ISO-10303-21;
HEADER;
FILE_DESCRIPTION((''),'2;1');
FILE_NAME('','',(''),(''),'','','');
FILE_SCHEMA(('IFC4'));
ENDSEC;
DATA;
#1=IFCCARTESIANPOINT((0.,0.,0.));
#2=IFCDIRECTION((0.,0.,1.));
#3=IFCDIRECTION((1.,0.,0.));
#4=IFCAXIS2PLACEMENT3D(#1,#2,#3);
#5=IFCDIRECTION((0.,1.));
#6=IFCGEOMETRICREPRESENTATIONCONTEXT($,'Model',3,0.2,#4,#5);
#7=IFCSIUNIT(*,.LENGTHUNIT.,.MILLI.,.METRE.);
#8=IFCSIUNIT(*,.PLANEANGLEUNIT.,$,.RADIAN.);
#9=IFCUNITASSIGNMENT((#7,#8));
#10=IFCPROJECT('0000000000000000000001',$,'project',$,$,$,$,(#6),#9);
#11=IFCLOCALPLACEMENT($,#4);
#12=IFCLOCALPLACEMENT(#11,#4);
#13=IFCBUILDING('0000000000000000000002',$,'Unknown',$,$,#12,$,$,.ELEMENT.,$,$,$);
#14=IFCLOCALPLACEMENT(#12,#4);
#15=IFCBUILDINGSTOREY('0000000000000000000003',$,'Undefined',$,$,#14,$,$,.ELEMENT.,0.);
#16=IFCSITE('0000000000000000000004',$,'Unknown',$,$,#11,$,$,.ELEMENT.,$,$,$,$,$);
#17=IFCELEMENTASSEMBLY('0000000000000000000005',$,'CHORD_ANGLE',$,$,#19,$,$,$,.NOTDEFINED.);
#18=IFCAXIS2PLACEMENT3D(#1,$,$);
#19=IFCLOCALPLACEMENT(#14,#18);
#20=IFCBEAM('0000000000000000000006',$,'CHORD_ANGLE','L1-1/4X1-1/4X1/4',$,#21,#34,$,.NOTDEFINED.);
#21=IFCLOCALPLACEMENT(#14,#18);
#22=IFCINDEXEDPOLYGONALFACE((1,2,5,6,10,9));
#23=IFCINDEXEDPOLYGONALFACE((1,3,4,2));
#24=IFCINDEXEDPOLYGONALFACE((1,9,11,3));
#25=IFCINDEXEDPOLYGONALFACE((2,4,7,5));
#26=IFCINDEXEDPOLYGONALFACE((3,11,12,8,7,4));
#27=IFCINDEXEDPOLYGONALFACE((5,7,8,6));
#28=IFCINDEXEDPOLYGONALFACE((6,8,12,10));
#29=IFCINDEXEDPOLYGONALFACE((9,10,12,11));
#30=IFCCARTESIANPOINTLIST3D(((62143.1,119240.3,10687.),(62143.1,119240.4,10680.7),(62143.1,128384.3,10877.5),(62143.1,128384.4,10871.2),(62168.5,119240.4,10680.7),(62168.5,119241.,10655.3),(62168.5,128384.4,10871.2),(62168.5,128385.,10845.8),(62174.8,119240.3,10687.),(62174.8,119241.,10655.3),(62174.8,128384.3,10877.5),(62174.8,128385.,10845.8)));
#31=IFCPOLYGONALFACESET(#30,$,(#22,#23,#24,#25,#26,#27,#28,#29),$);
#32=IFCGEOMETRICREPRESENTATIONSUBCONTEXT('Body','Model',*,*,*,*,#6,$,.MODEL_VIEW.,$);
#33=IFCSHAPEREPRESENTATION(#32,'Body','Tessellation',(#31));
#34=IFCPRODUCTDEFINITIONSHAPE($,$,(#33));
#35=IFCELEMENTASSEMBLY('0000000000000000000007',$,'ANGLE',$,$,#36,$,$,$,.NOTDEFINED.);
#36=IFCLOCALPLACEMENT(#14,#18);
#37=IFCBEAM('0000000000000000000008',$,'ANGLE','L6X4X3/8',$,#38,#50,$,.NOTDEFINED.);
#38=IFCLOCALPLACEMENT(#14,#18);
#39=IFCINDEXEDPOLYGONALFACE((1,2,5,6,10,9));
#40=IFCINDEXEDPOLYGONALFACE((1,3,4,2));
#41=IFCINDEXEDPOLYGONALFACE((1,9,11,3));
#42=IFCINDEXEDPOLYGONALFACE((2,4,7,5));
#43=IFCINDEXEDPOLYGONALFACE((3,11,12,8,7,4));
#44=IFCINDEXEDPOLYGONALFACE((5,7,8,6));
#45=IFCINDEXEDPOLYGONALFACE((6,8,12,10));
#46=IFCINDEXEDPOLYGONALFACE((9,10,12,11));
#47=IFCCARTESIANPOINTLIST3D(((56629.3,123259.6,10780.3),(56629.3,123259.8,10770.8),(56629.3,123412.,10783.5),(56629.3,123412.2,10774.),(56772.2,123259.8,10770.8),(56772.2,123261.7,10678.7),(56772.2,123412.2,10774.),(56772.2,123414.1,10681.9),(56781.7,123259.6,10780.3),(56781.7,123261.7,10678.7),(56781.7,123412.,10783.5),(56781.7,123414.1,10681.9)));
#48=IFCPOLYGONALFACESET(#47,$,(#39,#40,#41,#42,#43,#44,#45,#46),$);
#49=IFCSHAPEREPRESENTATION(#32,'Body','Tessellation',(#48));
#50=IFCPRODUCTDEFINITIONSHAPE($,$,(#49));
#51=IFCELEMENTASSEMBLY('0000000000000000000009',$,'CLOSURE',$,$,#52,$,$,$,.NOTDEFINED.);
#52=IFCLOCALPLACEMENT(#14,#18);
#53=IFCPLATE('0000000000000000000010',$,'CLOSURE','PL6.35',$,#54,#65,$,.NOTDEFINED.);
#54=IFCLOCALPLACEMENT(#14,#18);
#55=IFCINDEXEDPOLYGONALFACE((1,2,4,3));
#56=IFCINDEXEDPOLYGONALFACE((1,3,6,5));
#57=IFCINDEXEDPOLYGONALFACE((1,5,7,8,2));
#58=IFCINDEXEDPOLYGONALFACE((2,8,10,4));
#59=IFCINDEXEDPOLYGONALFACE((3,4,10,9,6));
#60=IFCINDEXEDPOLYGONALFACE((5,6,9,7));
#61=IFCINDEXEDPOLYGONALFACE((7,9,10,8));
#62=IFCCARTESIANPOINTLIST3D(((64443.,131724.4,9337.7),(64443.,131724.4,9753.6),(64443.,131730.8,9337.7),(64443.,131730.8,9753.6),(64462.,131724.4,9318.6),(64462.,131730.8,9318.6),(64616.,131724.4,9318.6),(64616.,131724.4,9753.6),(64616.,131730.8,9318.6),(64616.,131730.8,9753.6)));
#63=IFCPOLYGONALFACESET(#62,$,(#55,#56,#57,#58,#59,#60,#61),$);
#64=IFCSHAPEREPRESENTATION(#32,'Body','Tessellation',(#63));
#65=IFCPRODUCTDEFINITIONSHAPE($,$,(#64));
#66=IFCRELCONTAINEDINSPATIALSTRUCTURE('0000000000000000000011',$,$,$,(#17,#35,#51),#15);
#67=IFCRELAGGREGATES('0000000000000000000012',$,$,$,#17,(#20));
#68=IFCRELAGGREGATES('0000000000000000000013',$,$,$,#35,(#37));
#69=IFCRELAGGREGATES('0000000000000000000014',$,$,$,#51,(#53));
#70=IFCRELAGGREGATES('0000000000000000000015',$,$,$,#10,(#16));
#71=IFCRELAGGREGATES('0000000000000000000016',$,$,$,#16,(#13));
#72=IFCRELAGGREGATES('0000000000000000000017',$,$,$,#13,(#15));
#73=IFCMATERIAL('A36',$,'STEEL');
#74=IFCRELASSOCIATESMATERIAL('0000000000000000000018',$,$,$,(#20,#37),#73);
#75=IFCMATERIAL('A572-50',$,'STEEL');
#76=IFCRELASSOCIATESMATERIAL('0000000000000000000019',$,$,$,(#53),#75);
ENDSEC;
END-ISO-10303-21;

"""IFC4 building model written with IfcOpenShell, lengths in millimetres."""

from ifc_helpers import new_model, si_unit, direction, frame, origin_with_axes, place, context, subcontext, project, spatial, line, indexed_curve, outline, extrude, material, element, aggregate, save


model = new_model("IFC4")

# Units and contexts
model_context = context("Model", 3, precision=0.2, world=origin_with_axes(), true_north=direction((0.0, 1.0)))
body_context = subcontext(model_context, "Body", "Model", "MODEL_VIEW")
ifc_project = project(units=[si_unit("LENGTHUNIT", "METRE", prefix="MILLI"), si_unit("PLANEANGLEUNIT", "RADIAN")], contexts=[model_context])

# Site, building, storey
site_placement = place(None, origin_with_axes())
site = spatial("IfcSite", under=ifc_project, at=site_placement, Name="Unknown", CompositionType="ELEMENT")
building_placement = place(site_placement, origin_with_axes())
building = spatial("IfcBuilding", under=site, at=building_placement, Name="Unknown", CompositionType="ELEMENT")
storey_placement = place(building_placement, origin_with_axes())
storey = spatial("IfcBuildingStorey", under=building, at=storey_placement, Name="Undefined", CompositionType="ELEMENT", Elevation=0.0)

# Shared definitions
ifc_material_1 = material(Name="A572-50", Category="STEEL")

# Element assemblies, beams
ifc_material_2 = material(Name="A36", Category="STEEL")
assembly_1_placement = place(storey_placement, frame((62158.9, 128384.6, 10861.7), z_axis=(0.0, 0.020829, -0.999783), x_axis=(0.0, -0.999783, -0.020831)))
assembly_1 = element("IfcElementAssembly", 1, at=assembly_1_placement, inside=storey, Name="CHORD_ANGLE", PredefinedType="NOTDEFINED")
beam_1_placement = place(assembly_1_placement, origin_with_axes())
beam_1 = element("IfcBeam", 2, at=beam_1_placement, material=ifc_material_2, Name="CHORD_ANGLE", Description="L1-1/4X1-1/4X1/4", PredefinedType="NOTDEFINED", context=body_context, shape_type="SolidModel", body=[
    extrude(outline(indexed_curve([(-15.9, -15.9), (15.9, -15.9), (15.9, -9.5), (-9.5, -9.5), (-9.5, 15.9), (-15.9, 15.9)], segments=[line(1, 2, 3, 4, 5, 6, 1)])), frame((0.0, 0.0, 0.0), z_axis=(-1.0, 0.0, 0.0), x_axis=(0.0, 0.0, 1.0)), (0.0, 0.0, -1.0), 9146.0),
])
aggregate(assembly_1, [beam_1])
assembly_2_placement = place(storey_placement, frame((56705.5, 123413.0, 10732.7), z_axis=(0.0, 0.020829, -0.999783), x_axis=(0.0, -0.999783, -0.020831)))
assembly_2 = element("IfcElementAssembly", 3, at=assembly_2_placement, inside=storey, Name="ANGLE", PredefinedType="NOTDEFINED")
beam_2_placement = place(assembly_2_placement, origin_with_axes())
beam_2 = element("IfcBeam", 4, at=beam_2_placement, material=ifc_material_2, Name="ANGLE", Description="L6X4X3/8", PredefinedType="NOTDEFINED", context=body_context, shape_type="SolidModel", body=[
    extrude(outline(indexed_curve([(-50.8, -76.2), (50.8, -76.2), (50.8, -66.7), (-41.3, -66.7), (-41.3, 76.2), (-50.8, 76.2)], segments=[line(1, 2, 3, 4, 5, 6, 1)])), frame((0.0, 0.0, 0.0), z_axis=(-1.0, 0.0, 0.0), x_axis=(0.0, 0.0, 1.0)), (0.0, 0.0, -1.0), 152.4),
])
aggregate(assembly_2, [beam_2])

# Element assembly, plate
assembly_3_placement = place(storey_placement, frame((64616.0, 131727.6, 9318.6), z_axis=(0.0, 1.0, 0.0), x_axis=(-1.0, 0.0, 0.0)))
assembly_3 = element("IfcElementAssembly", 5, at=assembly_3_placement, inside=storey, Name="CLOSURE", PredefinedType="NOTDEFINED")
plate_placement = place(assembly_3_placement, origin_with_axes())
plate = element("IfcPlate", 6, at=plate_placement, material=ifc_material_1, Name="CLOSURE", Description="PL6.35", PredefinedType="NOTDEFINED", context=body_context, shape_type="SolidModel", body=[
    extrude(outline(indexed_curve([(0.0, 0.0), (154.0, 0.0), (173.0, 19.1), (173.0, 435.0), (0.0, 435.0)], segments=[line(1, 2, 3, 4, 5, 1)])), frame((0.0, 0.0, 3.2), z_axis=(0.0, 0.0, 1.0), x_axis=(1.0, 0.0, 0.0)), (0.0, 0.0, -1.0), 6.3),
])
aggregate(assembly_3, [plate])

save(model, "model.ifc")
